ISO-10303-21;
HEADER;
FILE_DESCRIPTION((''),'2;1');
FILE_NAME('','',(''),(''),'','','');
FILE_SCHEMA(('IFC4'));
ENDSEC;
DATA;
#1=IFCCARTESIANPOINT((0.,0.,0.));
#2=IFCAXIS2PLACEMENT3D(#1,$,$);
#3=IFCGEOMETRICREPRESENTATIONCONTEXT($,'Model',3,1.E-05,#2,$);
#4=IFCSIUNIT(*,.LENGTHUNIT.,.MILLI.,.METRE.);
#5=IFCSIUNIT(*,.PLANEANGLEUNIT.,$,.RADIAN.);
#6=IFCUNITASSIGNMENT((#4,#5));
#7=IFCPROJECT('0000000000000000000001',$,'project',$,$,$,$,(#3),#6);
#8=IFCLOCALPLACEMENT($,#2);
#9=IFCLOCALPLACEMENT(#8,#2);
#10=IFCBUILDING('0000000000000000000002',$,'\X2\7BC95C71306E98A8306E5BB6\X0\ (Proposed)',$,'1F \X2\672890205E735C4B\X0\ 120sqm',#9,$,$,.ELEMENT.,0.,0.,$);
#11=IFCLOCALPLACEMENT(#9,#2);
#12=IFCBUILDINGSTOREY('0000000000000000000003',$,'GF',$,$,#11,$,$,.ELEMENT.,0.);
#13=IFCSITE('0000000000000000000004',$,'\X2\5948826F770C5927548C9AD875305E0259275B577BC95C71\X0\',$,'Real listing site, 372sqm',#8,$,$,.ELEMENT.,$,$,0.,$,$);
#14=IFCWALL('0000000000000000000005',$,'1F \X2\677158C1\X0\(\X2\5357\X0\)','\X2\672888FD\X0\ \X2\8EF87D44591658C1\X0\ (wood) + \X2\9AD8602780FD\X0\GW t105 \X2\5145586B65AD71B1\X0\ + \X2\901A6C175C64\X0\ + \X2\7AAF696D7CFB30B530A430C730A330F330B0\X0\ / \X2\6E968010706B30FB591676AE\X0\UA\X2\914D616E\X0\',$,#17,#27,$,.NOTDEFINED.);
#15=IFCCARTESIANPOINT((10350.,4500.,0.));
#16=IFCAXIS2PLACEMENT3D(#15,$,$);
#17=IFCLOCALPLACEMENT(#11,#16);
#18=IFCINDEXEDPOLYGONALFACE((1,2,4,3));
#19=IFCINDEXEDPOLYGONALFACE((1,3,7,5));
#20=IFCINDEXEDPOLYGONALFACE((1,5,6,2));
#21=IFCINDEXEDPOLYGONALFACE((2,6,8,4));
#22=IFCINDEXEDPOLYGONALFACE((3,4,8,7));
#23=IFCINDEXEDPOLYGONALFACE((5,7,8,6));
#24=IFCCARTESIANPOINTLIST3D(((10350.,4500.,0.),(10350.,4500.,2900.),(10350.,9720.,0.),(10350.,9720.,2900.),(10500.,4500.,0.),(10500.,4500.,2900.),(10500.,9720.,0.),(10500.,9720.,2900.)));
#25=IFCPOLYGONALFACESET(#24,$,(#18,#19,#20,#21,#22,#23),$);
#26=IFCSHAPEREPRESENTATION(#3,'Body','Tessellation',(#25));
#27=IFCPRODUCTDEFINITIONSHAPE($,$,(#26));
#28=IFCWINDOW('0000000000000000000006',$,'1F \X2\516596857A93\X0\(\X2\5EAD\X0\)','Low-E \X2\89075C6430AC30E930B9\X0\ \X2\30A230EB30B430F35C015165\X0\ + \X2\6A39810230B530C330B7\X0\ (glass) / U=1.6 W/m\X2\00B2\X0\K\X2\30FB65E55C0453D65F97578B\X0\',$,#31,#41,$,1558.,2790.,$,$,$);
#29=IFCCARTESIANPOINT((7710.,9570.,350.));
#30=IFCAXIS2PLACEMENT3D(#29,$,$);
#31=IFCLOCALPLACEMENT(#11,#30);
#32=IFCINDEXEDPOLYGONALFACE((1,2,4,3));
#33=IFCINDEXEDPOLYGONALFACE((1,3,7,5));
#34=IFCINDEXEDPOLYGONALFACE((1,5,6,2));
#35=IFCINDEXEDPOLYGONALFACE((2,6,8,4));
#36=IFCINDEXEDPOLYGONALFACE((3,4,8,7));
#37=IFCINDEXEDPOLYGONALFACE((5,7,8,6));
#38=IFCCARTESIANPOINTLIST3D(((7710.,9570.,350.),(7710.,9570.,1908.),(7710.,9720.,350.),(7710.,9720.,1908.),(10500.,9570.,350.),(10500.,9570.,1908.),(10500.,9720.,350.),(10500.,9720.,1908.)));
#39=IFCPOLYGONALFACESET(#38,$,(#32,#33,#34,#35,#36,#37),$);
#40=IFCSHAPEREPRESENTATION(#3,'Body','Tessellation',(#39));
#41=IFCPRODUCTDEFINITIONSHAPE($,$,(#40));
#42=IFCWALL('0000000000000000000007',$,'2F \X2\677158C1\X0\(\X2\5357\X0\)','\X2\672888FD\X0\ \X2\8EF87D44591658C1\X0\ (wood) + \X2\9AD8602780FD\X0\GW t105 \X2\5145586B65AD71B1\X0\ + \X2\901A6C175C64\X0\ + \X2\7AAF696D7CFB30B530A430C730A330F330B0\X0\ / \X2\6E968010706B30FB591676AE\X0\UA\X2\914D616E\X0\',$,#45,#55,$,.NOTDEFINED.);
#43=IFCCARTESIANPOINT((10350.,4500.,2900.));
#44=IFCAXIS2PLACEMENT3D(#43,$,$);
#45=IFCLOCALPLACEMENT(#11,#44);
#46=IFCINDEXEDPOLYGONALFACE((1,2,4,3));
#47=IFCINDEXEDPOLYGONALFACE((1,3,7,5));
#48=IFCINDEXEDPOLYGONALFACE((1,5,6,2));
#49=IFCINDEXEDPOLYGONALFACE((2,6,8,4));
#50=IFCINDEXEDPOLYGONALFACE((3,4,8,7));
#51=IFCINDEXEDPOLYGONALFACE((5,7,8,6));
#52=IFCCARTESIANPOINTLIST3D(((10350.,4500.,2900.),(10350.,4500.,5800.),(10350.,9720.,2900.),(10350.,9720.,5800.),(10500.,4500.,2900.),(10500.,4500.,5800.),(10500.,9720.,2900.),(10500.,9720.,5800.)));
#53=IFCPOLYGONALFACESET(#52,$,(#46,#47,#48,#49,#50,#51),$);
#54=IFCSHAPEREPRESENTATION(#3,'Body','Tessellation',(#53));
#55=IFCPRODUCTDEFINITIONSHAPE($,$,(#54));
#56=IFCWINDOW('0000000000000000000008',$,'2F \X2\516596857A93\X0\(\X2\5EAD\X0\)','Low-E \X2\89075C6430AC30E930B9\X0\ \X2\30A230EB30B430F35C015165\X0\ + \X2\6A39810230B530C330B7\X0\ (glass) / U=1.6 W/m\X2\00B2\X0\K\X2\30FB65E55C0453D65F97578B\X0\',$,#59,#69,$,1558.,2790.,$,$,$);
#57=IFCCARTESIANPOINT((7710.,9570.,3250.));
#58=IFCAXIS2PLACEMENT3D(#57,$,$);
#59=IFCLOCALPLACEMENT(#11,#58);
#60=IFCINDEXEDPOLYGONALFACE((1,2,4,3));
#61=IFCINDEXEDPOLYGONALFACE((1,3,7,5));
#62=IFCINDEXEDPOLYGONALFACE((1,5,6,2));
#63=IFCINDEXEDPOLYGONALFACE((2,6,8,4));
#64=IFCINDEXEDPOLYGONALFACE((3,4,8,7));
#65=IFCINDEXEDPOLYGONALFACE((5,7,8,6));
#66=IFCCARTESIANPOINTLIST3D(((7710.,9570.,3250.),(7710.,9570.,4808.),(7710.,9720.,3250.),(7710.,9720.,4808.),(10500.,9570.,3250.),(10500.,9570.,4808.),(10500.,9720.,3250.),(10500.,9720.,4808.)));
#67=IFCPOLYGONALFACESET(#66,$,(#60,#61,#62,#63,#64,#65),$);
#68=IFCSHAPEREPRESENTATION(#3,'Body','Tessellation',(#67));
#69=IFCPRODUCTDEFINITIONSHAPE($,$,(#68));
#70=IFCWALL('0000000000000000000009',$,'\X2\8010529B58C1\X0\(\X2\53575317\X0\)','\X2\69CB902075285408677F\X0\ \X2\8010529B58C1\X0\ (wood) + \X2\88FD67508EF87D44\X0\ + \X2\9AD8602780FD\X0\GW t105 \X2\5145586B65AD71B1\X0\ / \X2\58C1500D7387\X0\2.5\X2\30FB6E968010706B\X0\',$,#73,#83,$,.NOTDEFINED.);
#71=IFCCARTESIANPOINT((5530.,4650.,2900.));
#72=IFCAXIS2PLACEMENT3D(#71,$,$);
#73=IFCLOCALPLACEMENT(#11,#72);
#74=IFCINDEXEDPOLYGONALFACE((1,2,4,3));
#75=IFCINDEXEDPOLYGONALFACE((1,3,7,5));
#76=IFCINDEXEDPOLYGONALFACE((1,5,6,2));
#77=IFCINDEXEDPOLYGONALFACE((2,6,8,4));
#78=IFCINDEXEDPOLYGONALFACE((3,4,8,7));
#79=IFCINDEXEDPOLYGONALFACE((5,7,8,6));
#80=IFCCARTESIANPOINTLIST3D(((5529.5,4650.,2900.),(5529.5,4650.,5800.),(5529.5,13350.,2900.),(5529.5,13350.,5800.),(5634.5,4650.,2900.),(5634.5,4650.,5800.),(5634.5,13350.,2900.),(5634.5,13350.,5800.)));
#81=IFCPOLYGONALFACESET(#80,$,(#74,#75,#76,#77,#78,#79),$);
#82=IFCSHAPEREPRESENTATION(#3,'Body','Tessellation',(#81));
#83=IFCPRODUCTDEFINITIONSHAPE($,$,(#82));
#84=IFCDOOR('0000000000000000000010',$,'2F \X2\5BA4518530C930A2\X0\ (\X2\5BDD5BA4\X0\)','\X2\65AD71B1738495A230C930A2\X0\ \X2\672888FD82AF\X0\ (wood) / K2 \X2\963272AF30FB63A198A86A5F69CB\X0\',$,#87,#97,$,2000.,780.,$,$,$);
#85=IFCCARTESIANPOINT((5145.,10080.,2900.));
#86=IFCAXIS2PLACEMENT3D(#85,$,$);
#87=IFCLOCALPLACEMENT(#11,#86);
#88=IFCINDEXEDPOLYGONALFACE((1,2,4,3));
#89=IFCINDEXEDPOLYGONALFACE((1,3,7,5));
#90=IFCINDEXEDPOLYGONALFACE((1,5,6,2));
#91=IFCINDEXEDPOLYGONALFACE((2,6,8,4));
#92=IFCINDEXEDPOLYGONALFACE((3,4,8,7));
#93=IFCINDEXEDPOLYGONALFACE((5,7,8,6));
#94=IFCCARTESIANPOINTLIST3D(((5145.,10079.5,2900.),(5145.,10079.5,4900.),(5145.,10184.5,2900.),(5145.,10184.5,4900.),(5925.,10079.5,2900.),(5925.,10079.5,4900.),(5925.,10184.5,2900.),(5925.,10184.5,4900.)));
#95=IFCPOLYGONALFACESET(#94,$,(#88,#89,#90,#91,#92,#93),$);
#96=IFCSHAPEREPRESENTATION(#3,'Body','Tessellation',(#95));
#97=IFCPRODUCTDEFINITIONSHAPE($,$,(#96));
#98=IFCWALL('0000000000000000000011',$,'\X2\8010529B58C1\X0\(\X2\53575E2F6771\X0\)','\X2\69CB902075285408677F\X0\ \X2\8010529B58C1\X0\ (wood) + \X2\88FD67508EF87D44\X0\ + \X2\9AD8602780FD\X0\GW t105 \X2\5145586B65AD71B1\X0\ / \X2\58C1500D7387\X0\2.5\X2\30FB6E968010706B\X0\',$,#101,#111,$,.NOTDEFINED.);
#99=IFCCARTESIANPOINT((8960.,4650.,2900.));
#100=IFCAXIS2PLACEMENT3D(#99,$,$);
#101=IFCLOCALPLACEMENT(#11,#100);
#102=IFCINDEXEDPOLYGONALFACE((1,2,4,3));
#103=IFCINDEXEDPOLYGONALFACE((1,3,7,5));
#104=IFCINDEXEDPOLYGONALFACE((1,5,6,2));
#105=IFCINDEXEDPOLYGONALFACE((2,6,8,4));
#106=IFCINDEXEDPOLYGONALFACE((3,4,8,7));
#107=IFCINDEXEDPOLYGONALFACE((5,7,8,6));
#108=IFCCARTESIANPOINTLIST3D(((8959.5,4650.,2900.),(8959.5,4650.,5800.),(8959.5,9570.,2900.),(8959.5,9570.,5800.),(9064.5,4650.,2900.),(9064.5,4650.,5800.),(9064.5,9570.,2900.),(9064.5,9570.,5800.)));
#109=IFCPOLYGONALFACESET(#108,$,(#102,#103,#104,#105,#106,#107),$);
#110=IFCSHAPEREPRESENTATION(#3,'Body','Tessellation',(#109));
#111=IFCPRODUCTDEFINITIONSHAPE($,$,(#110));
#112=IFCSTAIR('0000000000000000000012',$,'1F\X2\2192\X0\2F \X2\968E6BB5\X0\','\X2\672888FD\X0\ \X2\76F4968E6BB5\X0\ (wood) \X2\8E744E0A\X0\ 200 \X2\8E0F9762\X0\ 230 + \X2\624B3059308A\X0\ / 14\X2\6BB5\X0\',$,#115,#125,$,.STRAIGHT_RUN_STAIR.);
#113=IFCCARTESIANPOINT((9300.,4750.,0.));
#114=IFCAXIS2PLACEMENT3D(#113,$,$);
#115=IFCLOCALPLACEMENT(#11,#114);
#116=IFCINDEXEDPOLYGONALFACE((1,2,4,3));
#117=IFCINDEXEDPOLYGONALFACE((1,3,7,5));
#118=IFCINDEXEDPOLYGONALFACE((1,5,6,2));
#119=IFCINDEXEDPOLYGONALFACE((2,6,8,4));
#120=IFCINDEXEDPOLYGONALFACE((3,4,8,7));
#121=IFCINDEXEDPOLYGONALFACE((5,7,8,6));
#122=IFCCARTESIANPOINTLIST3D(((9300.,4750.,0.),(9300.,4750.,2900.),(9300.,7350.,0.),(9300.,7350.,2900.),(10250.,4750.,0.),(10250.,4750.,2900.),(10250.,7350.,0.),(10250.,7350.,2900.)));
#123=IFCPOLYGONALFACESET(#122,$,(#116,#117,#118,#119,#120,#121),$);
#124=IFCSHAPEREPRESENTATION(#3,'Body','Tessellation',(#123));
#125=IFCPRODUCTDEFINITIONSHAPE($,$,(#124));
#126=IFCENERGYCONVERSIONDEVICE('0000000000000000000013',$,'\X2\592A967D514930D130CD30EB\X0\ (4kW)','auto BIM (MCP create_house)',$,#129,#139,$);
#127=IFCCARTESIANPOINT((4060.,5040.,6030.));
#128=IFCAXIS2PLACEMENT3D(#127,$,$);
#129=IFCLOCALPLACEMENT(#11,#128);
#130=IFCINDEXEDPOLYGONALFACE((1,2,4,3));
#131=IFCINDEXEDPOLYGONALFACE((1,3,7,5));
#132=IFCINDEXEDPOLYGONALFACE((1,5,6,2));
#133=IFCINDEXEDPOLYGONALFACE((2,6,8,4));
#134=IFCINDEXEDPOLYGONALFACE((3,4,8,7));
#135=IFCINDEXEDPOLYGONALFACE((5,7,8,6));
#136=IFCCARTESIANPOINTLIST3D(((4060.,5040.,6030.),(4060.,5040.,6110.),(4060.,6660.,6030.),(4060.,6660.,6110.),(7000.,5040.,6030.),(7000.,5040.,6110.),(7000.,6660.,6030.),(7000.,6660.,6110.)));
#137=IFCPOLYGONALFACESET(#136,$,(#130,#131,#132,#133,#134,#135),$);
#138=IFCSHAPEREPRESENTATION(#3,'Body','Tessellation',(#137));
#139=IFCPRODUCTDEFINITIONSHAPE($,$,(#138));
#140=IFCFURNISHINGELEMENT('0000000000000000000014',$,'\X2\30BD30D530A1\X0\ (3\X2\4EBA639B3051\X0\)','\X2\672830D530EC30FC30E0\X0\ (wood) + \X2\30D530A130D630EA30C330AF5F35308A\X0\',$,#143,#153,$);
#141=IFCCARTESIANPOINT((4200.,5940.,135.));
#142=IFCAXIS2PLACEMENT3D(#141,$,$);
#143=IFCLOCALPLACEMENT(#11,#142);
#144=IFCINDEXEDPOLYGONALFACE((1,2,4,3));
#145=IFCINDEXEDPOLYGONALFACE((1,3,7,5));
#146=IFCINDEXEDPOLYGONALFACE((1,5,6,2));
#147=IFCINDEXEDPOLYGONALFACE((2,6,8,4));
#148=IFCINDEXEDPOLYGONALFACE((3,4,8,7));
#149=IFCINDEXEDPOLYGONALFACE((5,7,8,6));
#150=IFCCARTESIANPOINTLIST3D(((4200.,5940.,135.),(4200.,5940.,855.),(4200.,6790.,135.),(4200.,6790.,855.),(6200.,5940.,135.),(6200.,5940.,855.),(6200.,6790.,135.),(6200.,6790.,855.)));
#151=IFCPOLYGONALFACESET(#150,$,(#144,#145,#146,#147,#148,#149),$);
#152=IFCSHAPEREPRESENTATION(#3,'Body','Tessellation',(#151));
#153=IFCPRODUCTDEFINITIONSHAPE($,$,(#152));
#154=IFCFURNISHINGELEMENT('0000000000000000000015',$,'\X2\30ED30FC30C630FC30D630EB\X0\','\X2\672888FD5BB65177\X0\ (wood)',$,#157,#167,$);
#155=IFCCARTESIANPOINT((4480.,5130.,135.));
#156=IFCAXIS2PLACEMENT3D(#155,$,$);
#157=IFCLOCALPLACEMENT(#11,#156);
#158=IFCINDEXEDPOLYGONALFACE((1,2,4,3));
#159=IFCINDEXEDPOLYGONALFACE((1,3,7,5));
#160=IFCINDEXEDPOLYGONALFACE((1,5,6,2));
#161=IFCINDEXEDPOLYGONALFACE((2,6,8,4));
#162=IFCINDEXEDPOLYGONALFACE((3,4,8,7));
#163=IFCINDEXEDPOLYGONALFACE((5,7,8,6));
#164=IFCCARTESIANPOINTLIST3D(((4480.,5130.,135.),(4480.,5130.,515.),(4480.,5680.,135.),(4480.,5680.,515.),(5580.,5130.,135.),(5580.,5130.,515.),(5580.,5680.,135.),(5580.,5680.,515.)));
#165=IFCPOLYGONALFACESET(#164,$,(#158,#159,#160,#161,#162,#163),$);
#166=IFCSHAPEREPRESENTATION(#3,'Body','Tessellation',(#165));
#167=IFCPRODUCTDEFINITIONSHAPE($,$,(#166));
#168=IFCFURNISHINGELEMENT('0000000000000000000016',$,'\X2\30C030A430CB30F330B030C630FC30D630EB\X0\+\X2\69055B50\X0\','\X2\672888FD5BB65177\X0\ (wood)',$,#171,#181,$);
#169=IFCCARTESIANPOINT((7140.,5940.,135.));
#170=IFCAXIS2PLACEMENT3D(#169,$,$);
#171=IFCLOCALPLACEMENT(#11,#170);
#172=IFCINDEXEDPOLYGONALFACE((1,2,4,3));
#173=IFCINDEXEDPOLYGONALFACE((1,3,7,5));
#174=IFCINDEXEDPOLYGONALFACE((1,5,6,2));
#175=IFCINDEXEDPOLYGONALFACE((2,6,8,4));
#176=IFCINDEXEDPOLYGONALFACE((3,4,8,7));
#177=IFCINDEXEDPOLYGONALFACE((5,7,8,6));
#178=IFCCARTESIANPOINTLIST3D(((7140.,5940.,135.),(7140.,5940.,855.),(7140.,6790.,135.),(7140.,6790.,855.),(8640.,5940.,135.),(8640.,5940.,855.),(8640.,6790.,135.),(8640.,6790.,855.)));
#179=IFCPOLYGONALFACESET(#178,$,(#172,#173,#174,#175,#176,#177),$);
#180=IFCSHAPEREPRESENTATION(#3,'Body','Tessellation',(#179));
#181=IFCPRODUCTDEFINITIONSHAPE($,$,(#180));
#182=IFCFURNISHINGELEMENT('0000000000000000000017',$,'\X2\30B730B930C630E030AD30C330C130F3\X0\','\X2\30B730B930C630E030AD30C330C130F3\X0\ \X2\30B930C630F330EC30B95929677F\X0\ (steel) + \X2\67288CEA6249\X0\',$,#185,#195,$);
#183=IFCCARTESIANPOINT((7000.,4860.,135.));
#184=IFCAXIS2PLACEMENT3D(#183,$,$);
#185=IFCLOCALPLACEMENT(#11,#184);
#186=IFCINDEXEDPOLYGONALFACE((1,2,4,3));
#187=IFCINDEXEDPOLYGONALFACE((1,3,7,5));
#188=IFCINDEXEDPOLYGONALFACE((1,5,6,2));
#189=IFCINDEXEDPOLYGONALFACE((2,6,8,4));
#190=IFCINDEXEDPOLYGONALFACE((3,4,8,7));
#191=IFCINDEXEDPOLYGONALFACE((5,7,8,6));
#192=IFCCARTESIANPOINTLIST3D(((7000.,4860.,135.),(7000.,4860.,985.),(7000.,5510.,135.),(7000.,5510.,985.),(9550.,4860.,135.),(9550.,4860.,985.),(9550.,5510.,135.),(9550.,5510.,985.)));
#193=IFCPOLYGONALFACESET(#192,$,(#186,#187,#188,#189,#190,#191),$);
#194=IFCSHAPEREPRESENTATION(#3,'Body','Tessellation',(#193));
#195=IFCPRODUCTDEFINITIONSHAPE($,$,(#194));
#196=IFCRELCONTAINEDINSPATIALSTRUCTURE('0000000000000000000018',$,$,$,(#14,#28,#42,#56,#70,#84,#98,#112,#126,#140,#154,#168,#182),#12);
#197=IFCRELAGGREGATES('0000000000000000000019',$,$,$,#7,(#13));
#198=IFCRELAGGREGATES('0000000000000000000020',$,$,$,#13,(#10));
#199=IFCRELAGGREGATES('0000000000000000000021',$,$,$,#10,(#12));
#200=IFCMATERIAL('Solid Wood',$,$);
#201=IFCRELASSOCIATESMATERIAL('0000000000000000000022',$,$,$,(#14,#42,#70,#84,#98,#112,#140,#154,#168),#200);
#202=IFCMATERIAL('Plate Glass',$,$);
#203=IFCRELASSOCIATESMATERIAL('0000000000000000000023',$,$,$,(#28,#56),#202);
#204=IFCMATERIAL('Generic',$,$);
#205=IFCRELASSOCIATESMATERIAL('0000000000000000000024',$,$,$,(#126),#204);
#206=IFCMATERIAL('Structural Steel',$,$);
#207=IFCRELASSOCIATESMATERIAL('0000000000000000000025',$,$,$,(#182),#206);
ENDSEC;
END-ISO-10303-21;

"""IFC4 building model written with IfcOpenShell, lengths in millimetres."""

from ifc_helpers import new_model, si_unit, frame, frame_2d, origin, place, context, project, spatial, rectangle, extrude, material, element, fill, save


model = new_model("IFC4")

# Units and contexts
model_context = context("Model", 3, precision=1e-05, world=origin())
ifc_project = project(units=[si_unit("LENGTHUNIT", "METRE", prefix="MILLI"), si_unit("PLANEANGLEUNIT", "RADIAN")], contexts=[model_context])

# Site, building, storey
site_placement = place(None, origin())
site = spatial("IfcSite", under=ifc_project, at=site_placement, Name="奈良県大和高田市大字築山", ObjectType="Real listing site, 372sqm", CompositionType="ELEMENT", RefElevation=0.0)
building_placement = place(site_placement, origin())
building = spatial("IfcBuilding", under=site, at=building_placement, Name="築山の風の家 (Proposed)", ObjectType="1F 木造平屋 120sqm", CompositionType="ELEMENT", ElevationOfRefHeight=0.0, ElevationOfTerrain=0.0)
storey_placement = place(building_placement, origin())
storey = spatial("IfcBuildingStorey", under=building, at=storey_placement, Name="GF", CompositionType="ELEMENT", Elevation=0.0)

# Wall, opening, window
ifc_material_1 = material(Name="Solid Wood")
wall_1_placement = place(storey_placement, frame((10350.0, 4500.0, 0.0)))
wall_1 = element("IfcWall", 1, at=wall_1_placement, inside=storey, material=ifc_material_1, Name="1F 東壁(南)", Description="木製 軸組外壁 (wood) + 高性能GW t105 充填断熱 + 通気層 + 窯業系サイディング / 準耐火・外皮UA配慮", PredefinedType="NOTDEFINED", context=model_context, shape_type="SweptSolid", body=[
    extrude(rectangle(XDim=150.0, YDim=5220.0, at=frame_2d((75.0, 2610.0))), frame((10350.0, 4500.0, 0.0)), (0.0, 0.0, 1.0), 2900.0),
])
opening_1_placement = place(storey_placement, frame((7710.0, 9570.0, 350.0)))
opening_1 = element("IfcOpeningElement", 2, at=opening_1_placement, cuts=wall_1, PredefinedType="NOTDEFINED", context=model_context, shape_type="SweptSolid", body=[
    extrude(rectangle(XDim=2790.0, YDim=150.0, at=frame_2d((1395.0, 75.0))), frame((7710.0, 9570.0, 350.0)), (0.0, 0.0, 1.0), 1558.0),
])
ifc_material_2 = material(Name="Plate Glass")
window_1_placement = place(storey_placement, frame((7710.0, 9570.0, 350.0)))
window_1 = element("IfcWindow", 3, at=window_1_placement, inside=storey, material=ifc_material_2, Name="1F 入隅窓(庭)", Description="Low-E 複層ガラス アルゴン封入 + 樹脂サッシ (glass) / U=1.6 W/m²K・日射取得型", OverallHeight=1558.0, OverallWidth=2790.0, context=model_context, shape_type="SweptSolid", body=[
    extrude(rectangle(XDim=2790.0, YDim=150.0, at=frame_2d((1395.0, 75.0))), frame((7710.0, 9570.0, 350.0)), (0.0, 0.0, 1.0), 1558.0),
])
fill(opening_1, window_1)

# Wall, opening, window
wall_2_placement = place(storey_placement, frame((10350.0, 4500.0, 2900.0)))
wall_2 = element("IfcWall", 4, at=wall_2_placement, inside=storey, material=ifc_material_1, Name="2F 東壁(南)", Description="木製 軸組外壁 (wood) + 高性能GW t105 充填断熱 + 通気層 + 窯業系サイディング / 準耐火・外皮UA配慮", PredefinedType="NOTDEFINED", context=model_context, shape_type="SweptSolid", body=[
    extrude(rectangle(XDim=150.0, YDim=5220.0, at=frame_2d((75.0, 2610.0))), frame((10350.0, 4500.0, 2900.0)), (0.0, 0.0, 1.0), 2900.0),
])
opening_2_placement = place(storey_placement, frame((7710.0, 9570.0, 3250.0)))
opening_2 = element("IfcOpeningElement", 5, at=opening_2_placement, cuts=wall_2, PredefinedType="NOTDEFINED", context=model_context, shape_type="SweptSolid", body=[
    extrude(rectangle(XDim=2790.0, YDim=150.0, at=frame_2d((1395.0, 75.0))), frame((7710.0, 9570.0, 3250.0)), (0.0, 0.0, 1.0), 1558.0),
])
window_2_placement = place(storey_placement, frame((7710.0, 9570.0, 3250.0)))
window_2 = element("IfcWindow", 6, at=window_2_placement, inside=storey, material=ifc_material_2, Name="2F 入隅窓(庭)", Description="Low-E 複層ガラス アルゴン封入 + 樹脂サッシ (glass) / U=1.6 W/m²K・日射取得型", OverallHeight=1558.0, OverallWidth=2790.0, context=model_context, shape_type="SweptSolid", body=[
    extrude(rectangle(XDim=2790.0, YDim=150.0, at=frame_2d((1395.0, 75.0))), frame((7710.0, 9570.0, 3250.0)), (0.0, 0.0, 1.0), 1558.0),
])
fill(opening_2, window_2)

# Wall, opening, door
wall_3_placement = place(storey_placement, frame((5530.0, 4650.0, 2900.0)))
wall_3 = element("IfcWall", 7, at=wall_3_placement, inside=storey, material=ifc_material_1, Name="耐力壁(南北)", Description="構造用合板 耐力壁 (wood) + 製材軸組 + 高性能GW t105 充填断熱 / 壁倍率2.5・準耐火", PredefinedType="NOTDEFINED", context=model_context, shape_type="SweptSolid", body=[
    extrude(rectangle(XDim=105.0, YDim=8700.0, at=frame_2d((52.0, 4350.0))), frame((5530.0, 4650.0, 2900.0)), (0.0, 0.0, 1.0), 2900.0),
])
opening_3_placement = place(storey_placement, frame((5145.0, 10080.0, 2900.0)))
opening_3 = element("IfcOpeningElement", 8, at=opening_3_placement, cuts=wall_3, PredefinedType="NOTDEFINED", context=model_context, shape_type="SweptSolid", body=[
    extrude(rectangle(XDim=780.0, YDim=105.0, at=frame_2d((390.0, 52.0))), frame((5145.0, 10080.0, 2900.0)), (0.0, 0.0, 1.0), 2000.0),
])
door_1_placement = place(storey_placement, frame((5145.0, 10080.0, 2900.0)))
door_1 = element("IfcDoor", 9, at=door_1_placement, inside=storey, material=ifc_material_1, Name="2F 室内ドア (寝室)", Description="断熱玄関ドア 木製芯 (wood) / K2 防犯・採風機構", OverallHeight=2000.0, OverallWidth=780.0, context=model_context, shape_type="SweptSolid", body=[
    extrude(rectangle(XDim=780.0, YDim=105.0, at=frame_2d((390.0, 52.0))), frame((5145.0, 10080.0, 2900.0)), (0.0, 0.0, 1.0), 2000.0),
])
fill(opening_3, door_1)

# Wall
wall_4_placement = place(storey_placement, frame((8960.0, 4650.0, 2900.0)))
element("IfcWall", 10, at=wall_4_placement, inside=storey, material=ifc_material_1, Name="耐力壁(南帯東)", Description="構造用合板 耐力壁 (wood) + 製材軸組 + 高性能GW t105 充填断熱 / 壁倍率2.5・準耐火", PredefinedType="NOTDEFINED", context=model_context, shape_type="SweptSolid", body=[
    extrude(rectangle(XDim=105.0, YDim=4920.0, at=frame_2d((52.0, 2460.0))), frame((8960.0, 4650.0, 2900.0)), (0.0, 0.0, 1.0), 2900.0),
])

# Stair
stair_placement = place(storey_placement, frame((9300.0, 4750.0, 0.0)))
element("IfcStair", 11, at=stair_placement, inside=storey, material=ifc_material_1, Name="1F→2F 階段", Description="木製 直階段 (wood) 蹴上 200 踏面 230 + 手すり / 14段", PredefinedType="STRAIGHT_RUN_STAIR", context=model_context, shape_type="SweptSolid", body=[
    extrude(rectangle(XDim=950.0, YDim=2600.0, at=frame_2d((475.0, 1300.0))), frame((9300.0, 4750.0, 0.0)), (0.0, 0.0, 1.0), 2900.0),
])

# Energy conversion device
ifc_material_3 = material(Name="Generic")
energy_conversion_device_placement = place(storey_placement, frame((4060.0, 5040.0, 6030.0)))
element("IfcEnergyConversionDevice", 12, at=energy_conversion_device_placement, inside=storey, material=ifc_material_3, Name="太陽光パネル (4kW)", Description="auto BIM (MCP create_house)", context=model_context, shape_type="SweptSolid", body=[
    extrude(rectangle(XDim=2940.0, YDim=1620.0, at=frame_2d((1470.0, 810.0))), frame((4060.0, 5040.0, 6030.0)), (0.0, 0.0, 1.0), 80.0),
])

# Furnishing elements
furnishing_1_placement = place(storey_placement, frame((4200.0, 5940.0, 135.0)))
element("IfcFurnishingElement", 13, at=furnishing_1_placement, inside=storey, material=ifc_material_1, Name="ソファ (3人掛け)", Description="木フレーム (wood) + ファブリック張り", context=model_context, shape_type="SweptSolid", body=[
    extrude(rectangle(XDim=2000.0, YDim=850.0, at=frame_2d((1000.0, 425.0))), frame((4200.0, 5940.0, 135.0)), (0.0, 0.0, 1.0), 720.0),
])
furnishing_2_placement = place(storey_placement, frame((4480.0, 5130.0, 135.0)))
element("IfcFurnishingElement", 14, at=furnishing_2_placement, inside=storey, material=ifc_material_1, Name="ローテーブル", Description="木製家具 (wood)", context=model_context, shape_type="SweptSolid", body=[
    extrude(rectangle(XDim=1100.0, YDim=550.0, at=frame_2d((550.0, 275.0))), frame((4480.0, 5130.0, 135.0)), (0.0, 0.0, 1.0), 380.0),
])
furnishing_3_placement = place(storey_placement, frame((7140.0, 5940.0, 135.0)))
element("IfcFurnishingElement", 15, at=furnishing_3_placement, inside=storey, material=ifc_material_1, Name="ダイニングテーブル+椅子", Description="木製家具 (wood)", context=model_context, shape_type="SweptSolid", body=[
    extrude(rectangle(XDim=1500.0, YDim=850.0, at=frame_2d((750.0, 425.0))), frame((7140.0, 5940.0, 135.0)), (0.0, 0.0, 1.0), 720.0),
])
ifc_material_4 = material(Name="Structural Steel")
furnishing_4_placement = place(storey_placement, frame((7000.0, 4860.0, 135.0)))
element("IfcFurnishingElement", 16, at=furnishing_4_placement, inside=storey, material=ifc_material_4, Name="システムキッチン", Description="システムキッチン ステンレス天板 (steel) + 木質扉", context=model_context, shape_type="SweptSolid", body=[
    extrude(rectangle(XDim=2550.0, YDim=650.0, at=frame_2d((1275.0, 325.0))), frame((7000.0, 4860.0, 135.0)), (0.0, 0.0, 1.0), 850.0),
])

save(model, "model.ifc")
